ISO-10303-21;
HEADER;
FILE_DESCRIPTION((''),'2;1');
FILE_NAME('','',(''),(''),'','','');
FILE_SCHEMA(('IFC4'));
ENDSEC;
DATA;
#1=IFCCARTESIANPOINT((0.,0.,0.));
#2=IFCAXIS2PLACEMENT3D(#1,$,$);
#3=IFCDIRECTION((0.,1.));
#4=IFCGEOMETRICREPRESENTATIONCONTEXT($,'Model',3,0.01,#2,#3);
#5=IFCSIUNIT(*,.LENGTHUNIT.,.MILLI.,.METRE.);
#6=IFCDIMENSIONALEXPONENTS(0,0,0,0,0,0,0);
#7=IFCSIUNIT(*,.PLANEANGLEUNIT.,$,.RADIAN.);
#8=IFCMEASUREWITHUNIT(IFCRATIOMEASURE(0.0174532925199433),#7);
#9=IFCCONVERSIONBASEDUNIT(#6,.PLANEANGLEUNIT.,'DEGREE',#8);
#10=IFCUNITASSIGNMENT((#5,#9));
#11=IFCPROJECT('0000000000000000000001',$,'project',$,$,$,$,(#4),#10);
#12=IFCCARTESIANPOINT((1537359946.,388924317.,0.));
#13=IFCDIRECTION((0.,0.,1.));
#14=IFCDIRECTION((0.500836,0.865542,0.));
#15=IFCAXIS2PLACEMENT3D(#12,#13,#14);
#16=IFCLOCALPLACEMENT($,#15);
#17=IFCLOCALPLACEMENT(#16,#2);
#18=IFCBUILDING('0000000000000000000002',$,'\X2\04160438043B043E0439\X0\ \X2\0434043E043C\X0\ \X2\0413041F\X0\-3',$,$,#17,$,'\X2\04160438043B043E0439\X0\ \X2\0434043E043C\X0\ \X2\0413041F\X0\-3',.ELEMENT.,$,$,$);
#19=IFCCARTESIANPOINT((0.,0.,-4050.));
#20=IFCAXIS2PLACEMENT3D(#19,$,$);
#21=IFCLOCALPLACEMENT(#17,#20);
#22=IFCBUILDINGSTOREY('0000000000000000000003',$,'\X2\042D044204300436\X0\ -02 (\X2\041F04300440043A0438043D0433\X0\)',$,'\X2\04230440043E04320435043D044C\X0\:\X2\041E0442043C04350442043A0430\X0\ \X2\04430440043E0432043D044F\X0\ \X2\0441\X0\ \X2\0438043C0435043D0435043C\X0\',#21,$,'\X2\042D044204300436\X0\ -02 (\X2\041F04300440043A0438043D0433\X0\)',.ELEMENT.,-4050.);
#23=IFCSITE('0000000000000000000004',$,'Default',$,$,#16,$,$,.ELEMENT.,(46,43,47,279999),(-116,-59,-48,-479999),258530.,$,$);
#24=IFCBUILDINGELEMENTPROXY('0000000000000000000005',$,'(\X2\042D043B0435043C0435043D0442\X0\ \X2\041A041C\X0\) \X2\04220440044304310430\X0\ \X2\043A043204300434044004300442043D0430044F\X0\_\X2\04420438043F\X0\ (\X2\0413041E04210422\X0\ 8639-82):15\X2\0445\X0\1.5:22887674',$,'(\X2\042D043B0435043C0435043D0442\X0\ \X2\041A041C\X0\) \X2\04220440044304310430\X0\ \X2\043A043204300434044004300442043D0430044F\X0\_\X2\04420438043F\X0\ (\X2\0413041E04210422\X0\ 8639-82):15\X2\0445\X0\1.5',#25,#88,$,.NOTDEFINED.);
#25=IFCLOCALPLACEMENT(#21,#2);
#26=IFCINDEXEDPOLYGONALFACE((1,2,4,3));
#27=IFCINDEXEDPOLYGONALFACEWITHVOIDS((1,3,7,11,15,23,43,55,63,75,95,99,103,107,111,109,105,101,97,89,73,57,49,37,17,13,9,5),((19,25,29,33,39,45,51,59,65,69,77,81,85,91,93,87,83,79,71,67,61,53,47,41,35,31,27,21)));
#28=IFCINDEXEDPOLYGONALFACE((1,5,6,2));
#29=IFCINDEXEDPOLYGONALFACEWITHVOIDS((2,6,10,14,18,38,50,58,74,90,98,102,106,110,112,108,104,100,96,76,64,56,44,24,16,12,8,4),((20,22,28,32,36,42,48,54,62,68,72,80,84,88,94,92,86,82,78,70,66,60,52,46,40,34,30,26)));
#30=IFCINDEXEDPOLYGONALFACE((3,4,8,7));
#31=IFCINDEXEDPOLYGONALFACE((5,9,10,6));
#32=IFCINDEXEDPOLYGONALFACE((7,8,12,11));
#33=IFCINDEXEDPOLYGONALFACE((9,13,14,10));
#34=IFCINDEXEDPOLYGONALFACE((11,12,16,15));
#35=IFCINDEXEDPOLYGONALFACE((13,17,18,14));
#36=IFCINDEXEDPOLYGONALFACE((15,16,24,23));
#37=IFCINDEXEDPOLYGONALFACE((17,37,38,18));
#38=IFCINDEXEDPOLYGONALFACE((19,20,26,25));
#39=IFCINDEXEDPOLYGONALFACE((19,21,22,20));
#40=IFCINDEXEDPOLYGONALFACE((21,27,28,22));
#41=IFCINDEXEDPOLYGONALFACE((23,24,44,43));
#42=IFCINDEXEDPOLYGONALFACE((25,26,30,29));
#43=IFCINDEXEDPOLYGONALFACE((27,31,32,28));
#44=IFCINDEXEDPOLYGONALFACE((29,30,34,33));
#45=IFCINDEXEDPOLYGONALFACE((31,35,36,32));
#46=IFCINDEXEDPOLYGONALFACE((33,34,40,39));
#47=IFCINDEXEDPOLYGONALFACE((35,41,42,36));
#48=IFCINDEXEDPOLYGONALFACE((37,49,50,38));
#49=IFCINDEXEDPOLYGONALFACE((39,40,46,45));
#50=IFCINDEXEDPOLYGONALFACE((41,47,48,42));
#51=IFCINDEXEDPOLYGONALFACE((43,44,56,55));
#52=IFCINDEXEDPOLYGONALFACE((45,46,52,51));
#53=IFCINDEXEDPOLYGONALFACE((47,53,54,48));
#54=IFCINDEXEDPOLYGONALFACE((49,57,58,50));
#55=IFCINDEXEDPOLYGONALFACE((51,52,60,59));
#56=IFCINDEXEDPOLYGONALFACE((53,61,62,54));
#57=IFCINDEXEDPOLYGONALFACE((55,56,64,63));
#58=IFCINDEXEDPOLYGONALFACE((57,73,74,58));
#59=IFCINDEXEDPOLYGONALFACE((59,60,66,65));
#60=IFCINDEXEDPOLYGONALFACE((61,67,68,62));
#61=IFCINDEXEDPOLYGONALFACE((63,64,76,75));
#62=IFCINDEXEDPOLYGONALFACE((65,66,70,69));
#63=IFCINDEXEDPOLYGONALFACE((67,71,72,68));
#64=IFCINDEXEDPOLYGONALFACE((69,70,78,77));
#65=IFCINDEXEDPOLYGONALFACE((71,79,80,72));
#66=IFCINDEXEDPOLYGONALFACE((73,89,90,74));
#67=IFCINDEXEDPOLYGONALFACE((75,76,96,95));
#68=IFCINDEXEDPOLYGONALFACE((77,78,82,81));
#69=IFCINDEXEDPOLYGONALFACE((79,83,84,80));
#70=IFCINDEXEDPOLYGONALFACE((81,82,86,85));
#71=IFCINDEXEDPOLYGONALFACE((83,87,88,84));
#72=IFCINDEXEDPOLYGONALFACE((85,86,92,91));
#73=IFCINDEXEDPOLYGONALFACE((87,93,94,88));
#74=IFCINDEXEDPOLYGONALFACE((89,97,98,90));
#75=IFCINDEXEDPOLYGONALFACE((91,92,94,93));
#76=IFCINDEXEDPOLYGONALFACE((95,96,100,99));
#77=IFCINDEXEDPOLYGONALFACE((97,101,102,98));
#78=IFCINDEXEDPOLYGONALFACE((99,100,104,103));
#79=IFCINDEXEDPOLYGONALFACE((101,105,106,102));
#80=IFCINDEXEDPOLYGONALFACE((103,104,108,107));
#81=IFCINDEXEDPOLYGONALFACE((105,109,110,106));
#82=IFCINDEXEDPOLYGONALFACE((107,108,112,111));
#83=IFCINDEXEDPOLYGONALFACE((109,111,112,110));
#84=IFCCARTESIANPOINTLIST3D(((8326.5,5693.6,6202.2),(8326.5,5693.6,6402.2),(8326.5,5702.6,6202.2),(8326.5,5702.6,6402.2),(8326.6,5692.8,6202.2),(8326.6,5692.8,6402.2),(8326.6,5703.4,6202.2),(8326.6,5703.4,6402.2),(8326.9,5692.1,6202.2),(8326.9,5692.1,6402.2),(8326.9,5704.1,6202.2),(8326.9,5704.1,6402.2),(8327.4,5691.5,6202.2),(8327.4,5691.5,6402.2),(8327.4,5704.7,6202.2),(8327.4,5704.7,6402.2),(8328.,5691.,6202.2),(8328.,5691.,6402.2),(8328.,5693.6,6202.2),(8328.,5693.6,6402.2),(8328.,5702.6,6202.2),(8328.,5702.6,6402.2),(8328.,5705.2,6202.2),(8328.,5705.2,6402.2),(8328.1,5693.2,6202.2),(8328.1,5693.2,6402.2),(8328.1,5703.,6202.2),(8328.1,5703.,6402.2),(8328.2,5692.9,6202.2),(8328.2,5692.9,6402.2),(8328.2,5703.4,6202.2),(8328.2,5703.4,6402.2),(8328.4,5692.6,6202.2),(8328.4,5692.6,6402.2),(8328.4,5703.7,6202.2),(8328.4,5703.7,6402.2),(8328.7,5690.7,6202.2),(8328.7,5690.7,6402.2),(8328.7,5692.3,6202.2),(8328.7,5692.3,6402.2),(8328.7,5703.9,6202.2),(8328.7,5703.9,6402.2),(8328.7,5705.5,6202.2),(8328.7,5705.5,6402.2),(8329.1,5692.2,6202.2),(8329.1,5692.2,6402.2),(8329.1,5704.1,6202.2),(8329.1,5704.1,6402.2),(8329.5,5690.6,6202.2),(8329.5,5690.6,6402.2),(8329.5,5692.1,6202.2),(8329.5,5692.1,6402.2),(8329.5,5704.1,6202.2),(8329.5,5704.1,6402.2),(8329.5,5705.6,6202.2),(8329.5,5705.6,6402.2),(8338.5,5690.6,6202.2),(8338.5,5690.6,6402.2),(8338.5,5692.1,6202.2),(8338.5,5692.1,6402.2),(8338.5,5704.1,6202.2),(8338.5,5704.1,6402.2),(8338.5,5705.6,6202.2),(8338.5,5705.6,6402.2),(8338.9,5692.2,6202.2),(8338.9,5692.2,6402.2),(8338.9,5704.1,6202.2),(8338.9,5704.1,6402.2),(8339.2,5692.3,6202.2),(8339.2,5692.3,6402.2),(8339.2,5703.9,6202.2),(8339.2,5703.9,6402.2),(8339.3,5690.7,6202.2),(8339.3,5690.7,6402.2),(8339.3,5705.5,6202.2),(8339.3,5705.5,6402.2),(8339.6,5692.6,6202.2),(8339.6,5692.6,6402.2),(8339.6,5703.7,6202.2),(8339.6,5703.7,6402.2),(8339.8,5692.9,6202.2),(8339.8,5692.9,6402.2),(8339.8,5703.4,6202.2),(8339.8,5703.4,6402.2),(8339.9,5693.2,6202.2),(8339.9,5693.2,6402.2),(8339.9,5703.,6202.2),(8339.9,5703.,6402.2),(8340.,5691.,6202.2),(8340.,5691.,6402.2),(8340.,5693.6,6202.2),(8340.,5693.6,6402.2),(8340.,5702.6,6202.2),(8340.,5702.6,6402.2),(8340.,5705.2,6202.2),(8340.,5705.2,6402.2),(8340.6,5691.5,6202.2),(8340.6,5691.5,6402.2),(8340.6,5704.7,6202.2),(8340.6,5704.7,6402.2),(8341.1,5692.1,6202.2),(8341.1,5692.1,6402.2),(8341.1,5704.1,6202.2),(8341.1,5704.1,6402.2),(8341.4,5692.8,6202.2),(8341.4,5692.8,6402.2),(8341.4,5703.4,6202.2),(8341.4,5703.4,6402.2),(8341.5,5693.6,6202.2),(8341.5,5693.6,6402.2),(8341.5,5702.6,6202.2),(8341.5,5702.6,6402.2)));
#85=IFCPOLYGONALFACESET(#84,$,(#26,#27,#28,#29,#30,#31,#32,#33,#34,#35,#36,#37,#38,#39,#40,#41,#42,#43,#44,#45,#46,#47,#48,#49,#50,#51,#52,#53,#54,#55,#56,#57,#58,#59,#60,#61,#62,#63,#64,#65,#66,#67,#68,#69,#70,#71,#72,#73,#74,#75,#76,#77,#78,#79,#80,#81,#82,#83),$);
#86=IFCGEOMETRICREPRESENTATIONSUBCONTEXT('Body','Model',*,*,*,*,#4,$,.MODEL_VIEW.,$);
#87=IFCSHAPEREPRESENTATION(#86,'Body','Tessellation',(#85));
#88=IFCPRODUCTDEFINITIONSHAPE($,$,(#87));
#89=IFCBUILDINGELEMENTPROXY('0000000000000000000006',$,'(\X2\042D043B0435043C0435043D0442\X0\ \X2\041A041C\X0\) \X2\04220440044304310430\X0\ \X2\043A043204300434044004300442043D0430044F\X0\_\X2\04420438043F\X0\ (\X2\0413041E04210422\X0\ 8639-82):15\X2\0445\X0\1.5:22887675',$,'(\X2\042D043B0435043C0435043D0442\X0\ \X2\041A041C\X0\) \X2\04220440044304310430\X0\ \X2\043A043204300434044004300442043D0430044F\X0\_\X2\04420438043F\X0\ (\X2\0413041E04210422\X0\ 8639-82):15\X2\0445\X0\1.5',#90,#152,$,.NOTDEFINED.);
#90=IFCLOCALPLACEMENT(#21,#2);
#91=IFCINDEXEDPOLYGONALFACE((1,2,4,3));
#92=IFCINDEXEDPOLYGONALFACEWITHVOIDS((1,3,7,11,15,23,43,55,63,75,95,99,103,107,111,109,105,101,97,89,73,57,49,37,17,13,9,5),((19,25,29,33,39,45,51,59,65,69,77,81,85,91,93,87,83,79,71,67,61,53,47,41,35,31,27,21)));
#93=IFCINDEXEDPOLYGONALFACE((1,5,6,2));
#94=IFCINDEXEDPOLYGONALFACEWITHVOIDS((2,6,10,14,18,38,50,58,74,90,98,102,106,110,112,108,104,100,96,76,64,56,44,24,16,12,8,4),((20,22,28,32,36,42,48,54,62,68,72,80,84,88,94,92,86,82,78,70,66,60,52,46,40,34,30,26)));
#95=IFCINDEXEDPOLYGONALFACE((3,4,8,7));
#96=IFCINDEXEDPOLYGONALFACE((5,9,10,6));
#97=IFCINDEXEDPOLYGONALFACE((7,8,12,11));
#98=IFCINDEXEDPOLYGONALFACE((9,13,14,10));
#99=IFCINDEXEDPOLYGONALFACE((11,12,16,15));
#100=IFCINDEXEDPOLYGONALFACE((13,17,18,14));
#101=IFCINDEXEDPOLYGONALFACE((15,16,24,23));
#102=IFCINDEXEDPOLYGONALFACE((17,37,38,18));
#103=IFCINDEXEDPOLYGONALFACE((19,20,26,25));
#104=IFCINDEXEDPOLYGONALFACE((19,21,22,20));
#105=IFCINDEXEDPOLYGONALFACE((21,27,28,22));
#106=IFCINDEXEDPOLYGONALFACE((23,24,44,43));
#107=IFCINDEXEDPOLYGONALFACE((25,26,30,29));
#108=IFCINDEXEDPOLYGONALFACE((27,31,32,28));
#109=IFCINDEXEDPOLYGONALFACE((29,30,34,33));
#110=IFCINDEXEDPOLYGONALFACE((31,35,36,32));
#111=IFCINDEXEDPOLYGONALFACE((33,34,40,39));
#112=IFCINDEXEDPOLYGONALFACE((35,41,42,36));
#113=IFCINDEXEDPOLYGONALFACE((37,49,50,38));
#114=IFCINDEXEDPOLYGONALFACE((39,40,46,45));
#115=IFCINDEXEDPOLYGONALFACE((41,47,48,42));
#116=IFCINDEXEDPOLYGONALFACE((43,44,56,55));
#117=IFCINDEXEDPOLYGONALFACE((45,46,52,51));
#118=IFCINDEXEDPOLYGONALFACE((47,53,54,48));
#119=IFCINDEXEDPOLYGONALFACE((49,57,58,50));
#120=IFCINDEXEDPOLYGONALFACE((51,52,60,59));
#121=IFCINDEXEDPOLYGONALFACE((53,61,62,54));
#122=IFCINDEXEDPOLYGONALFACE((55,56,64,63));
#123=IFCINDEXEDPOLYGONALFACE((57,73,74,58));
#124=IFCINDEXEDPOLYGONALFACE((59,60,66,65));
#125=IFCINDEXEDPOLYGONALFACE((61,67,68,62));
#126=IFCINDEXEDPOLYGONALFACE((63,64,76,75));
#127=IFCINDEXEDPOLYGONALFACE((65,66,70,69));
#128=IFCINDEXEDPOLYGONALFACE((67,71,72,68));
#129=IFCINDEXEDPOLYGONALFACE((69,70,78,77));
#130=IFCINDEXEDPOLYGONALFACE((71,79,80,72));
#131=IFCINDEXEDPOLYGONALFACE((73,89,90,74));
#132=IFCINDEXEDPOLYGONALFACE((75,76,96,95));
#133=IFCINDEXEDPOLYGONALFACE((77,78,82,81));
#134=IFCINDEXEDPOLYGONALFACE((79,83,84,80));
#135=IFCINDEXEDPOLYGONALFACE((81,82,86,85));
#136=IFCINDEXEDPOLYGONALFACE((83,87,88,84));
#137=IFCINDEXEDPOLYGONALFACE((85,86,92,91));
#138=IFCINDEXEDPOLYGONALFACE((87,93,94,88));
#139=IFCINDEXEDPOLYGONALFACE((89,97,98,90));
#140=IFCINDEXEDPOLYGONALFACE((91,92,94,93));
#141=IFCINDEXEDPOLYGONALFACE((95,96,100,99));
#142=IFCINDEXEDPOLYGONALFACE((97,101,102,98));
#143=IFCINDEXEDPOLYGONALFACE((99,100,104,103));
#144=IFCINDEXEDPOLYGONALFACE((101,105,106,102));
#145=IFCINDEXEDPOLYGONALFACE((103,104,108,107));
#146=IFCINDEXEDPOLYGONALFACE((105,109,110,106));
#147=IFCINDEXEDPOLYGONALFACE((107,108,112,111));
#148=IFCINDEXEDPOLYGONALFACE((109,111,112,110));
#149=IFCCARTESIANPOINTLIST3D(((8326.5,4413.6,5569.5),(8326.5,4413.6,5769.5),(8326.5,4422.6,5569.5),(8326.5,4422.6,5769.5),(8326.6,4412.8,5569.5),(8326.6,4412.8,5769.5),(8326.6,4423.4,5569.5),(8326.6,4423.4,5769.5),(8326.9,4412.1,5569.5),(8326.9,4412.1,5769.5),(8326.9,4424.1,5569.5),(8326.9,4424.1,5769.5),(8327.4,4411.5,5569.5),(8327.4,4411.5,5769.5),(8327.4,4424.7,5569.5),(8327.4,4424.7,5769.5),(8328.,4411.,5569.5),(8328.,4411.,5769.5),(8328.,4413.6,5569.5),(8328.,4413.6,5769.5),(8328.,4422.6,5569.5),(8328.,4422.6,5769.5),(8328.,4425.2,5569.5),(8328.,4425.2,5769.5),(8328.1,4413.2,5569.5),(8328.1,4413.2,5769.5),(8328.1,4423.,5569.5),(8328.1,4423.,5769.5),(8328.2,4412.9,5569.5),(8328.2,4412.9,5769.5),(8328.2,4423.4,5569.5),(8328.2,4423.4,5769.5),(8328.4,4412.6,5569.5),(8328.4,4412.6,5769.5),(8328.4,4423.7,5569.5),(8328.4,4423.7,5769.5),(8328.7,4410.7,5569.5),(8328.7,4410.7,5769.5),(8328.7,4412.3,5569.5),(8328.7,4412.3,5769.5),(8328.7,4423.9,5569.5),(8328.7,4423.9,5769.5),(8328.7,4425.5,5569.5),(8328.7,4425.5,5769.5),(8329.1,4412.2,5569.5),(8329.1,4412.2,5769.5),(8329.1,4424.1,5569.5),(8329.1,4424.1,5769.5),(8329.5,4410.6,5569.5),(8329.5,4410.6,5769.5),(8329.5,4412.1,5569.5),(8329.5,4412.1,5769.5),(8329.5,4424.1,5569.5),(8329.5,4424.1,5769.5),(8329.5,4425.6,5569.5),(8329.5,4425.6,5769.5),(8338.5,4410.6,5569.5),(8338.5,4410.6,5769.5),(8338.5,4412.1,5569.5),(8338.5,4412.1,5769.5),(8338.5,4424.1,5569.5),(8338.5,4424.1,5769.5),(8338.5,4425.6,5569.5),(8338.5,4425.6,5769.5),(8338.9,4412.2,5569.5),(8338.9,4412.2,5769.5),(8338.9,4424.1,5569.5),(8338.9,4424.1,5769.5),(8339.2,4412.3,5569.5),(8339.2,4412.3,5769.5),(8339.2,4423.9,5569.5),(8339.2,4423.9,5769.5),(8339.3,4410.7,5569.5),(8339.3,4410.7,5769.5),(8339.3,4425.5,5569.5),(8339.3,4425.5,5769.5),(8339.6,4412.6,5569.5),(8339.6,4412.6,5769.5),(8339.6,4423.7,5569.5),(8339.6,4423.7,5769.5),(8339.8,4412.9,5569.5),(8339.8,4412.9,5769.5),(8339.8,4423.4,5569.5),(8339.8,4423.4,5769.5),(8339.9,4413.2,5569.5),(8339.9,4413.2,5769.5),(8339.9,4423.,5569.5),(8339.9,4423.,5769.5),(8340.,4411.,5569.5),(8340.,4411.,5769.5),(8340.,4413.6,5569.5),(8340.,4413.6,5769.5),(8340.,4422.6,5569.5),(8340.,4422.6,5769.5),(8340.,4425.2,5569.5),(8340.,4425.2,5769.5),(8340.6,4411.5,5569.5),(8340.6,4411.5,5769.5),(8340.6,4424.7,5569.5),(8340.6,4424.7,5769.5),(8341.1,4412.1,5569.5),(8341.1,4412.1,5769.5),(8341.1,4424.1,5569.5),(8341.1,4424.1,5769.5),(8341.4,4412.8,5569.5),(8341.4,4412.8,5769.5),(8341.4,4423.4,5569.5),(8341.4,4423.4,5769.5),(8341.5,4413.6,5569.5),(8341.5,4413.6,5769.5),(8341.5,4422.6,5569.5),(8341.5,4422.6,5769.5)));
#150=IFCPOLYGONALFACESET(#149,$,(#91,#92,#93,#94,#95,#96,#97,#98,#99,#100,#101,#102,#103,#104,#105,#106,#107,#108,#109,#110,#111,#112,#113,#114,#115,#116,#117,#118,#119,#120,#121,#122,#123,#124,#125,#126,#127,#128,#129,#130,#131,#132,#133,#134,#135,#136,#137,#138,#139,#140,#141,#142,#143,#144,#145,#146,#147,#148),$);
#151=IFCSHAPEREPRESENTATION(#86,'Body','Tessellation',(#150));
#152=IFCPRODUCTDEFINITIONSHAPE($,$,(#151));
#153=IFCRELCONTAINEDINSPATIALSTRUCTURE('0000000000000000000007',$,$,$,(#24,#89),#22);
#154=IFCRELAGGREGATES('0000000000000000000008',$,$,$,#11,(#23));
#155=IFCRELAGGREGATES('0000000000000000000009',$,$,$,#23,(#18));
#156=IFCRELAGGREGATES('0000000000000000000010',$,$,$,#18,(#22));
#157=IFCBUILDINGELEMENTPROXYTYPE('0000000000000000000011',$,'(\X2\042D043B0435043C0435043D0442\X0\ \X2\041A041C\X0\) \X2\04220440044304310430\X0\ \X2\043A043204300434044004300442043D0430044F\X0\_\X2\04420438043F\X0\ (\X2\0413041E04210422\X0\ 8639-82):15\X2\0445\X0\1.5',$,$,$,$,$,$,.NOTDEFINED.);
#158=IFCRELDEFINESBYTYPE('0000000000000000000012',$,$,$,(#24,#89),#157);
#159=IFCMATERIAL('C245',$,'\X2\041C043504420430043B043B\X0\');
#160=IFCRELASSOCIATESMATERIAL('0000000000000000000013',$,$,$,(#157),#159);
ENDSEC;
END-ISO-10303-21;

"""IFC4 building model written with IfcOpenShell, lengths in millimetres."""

from ifc_helpers import new_model, entity, si_unit, converted_unit, direction, frame, frame_2d, origin, place, context, subcontext, project, spatial, polyline, circle_curve, parameter, trimmed, segment, composite_curve, outline, extrude, source, transform, mapped, material, type_object, type_shapes, element, save


model = new_model("IFC4")

# Units and contexts
model_context = context("Model", 3, precision=0.01, world=origin(), true_north=direction((0.0, 1.0)))
body_context = subcontext(model_context, "Body", "Model", "MODEL_VIEW")
ifc_project = project(units=[si_unit("LENGTHUNIT", "METRE", prefix="MILLI"), converted_unit("PLANEANGLEUNIT", "DEGREE", entity("IfcRatioMeasure", 0.0174532925199433), si_unit("PLANEANGLEUNIT", "RADIAN"), dimensions=[0, 0, 0, 0, 0, 0, 0])], contexts=[model_context])

# Site, building, storey
site_placement = place(None, frame((1537359946.0, 388924317.0, 0.0), z_axis=(0.0, 0.0, 1.0), x_axis=(0.500836, 0.865542, 0.0)))
site = spatial("IfcSite", under=ifc_project, at=site_placement, Name="Default", CompositionType="ELEMENT", RefLatitude=(46, 43, 47, 279999), RefLongitude=(-116, -59, -48, -479999), RefElevation=258530.0)
building_placement = place(site_placement, origin())
building = spatial("IfcBuilding", under=site, at=building_placement, Name="Жилой дом ГП-3", LongName="Жилой дом ГП-3", CompositionType="ELEMENT")
storey_placement = place(building_placement, frame((0.0, 0.0, -4050.0)))
storey = spatial("IfcBuildingStorey", under=building, at=storey_placement, Name="Этаж -02 (Паркинг)", ObjectType="Уровень:Отметка уровня с именем", LongName="Этаж -02 (Паркинг)", CompositionType="ELEMENT", Elevation=-4050.0)

# Building element proxies
ifc_material_1 = material(Name="C245", Category="Металл")
building_element_proxy_type_1 = type_object("IfcBuildingElementProxyType", Name="(Элемент КМ) Труба квадратная_тип (ГОСТ 8639-82):15х1.5", PredefinedType="NOTDEFINED", material=ifc_material_1)
shared_shape_1 = source(origin(), body_context, "Body", "SweptSolid", [
    extrude(outline(composite_curve([segment(trimmed(circle_curve(frame_2d((4.5, -4.5), x_axis=(1.0, 0.0)), 3.0), [parameter(270.0)], [parameter(0.0)], True, "PARAMETER"), True, "CONTINUOUS"), segment(polyline([(7.5, -4.5), (7.5, 4.5)]), True, "CONTINUOUS"), segment(trimmed(circle_curve(frame_2d((4.5, 4.5), x_axis=(1.0, 0.0)), 3.0), [parameter(0.0)], [parameter(90.0)], True, "PARAMETER"), True, "CONTINUOUS"), segment(polyline([(4.5, 7.5), (-4.5, 7.5)]), True, "CONTINUOUS"), segment(trimmed(circle_curve(frame_2d((-4.5, 4.5), x_axis=(1.0, 0.0)), 3.0), [parameter(90.0)], [parameter(180.0)], True, "PARAMETER"), True, "CONTINUOUS"), segment(polyline([(-7.5, 4.5), (-7.5, -4.5)]), True, "CONTINUOUS"), segment(trimmed(circle_curve(frame_2d((-4.5, -4.5), x_axis=(1.0, 0.0)), 3.0), [parameter(180.0)], [parameter(270.0)], True, "PARAMETER"), True, "CONTINUOUS"), segment(polyline([(-4.5, -7.5), (4.5, -7.5)]), True, "CONTINUOUS")], self_intersect=False), holes=[composite_curve([segment(polyline([(4.5, -6.0), (-4.5, -6.0)]), True, "CONTINUOUS"), segment(trimmed(circle_curve(frame_2d((-4.5, -4.5), x_axis=(1.0, 0.0)), 1.5), [parameter(180.0)], [parameter(270.0)], True, "PARAMETER"), False, "CONTINUOUS"), segment(polyline([(-6.0, -4.5), (-6.0, 4.5)]), True, "CONTINUOUS"), segment(trimmed(circle_curve(frame_2d((-4.5, 4.5), x_axis=(1.0, 0.0)), 1.5), [parameter(90.0)], [parameter(180.0)], True, "PARAMETER"), False, "CONTINUOUS"), segment(polyline([(-4.5, 6.0), (4.5, 6.0)]), True, "CONTINUOUS"), segment(trimmed(circle_curve(frame_2d((4.5, 4.5), x_axis=(1.0, 0.0)), 1.5), [parameter(0.0)], [parameter(90.0)], True, "PARAMETER"), False, "CONTINUOUS"), segment(polyline([(6.0, 4.5), (6.0, -4.5)]), True, "CONTINUOUS"), segment(trimmed(circle_curve(frame_2d((4.5, -4.5), x_axis=(1.0, 0.0)), 1.5), [parameter(270.0)], [parameter(0.0)], True, "PARAMETER"), False, "CONTINUOUS")], self_intersect=False)]), frame((-100.0, 0.0, 0.0), z_axis=(1.0, 0.0, 0.0), x_axis=(0.0, -1.0, 0.0)), (0.0, 0.0, 1.0), 200.0),
])
type_shapes(building_element_proxy_type_1, [shared_shape_1])
for number, where, z_axis, x_axis, name in (
    (1, (8334.0, 5698.1, 6302.2), (1.0, 0.0, 0.0), (0.0, 0.0, 1.0), "(Элемент КМ) Труба квадратная_тип (ГОСТ 8639-82):15х1.5:22887674"),
    (2, (8334.0, 4418.1, 5669.5), (1.0, 0.0, 0.0), (0.0, 0.0, 1.0), "(Элемент КМ) Труба квадратная_тип (ГОСТ 8639-82):15х1.5:22887675"),
):
    element("IfcBuildingElementProxy", number, at=place(storey_placement, frame(where, z_axis=z_axis, x_axis=x_axis)), inside=storey, type_object=building_element_proxy_type_1, Name=name, ObjectType="(Элемент КМ) Труба квадратная_тип (ГОСТ 8639-82):15х1.5", PredefinedType="NOTDEFINED", context=body_context, shape_type="MappedRepresentation", body=[
        mapped(shared_shape_1, transform((0.0, 0.0, 0.0), scale=1.0)),
    ])

save(model, "model.ifc")
